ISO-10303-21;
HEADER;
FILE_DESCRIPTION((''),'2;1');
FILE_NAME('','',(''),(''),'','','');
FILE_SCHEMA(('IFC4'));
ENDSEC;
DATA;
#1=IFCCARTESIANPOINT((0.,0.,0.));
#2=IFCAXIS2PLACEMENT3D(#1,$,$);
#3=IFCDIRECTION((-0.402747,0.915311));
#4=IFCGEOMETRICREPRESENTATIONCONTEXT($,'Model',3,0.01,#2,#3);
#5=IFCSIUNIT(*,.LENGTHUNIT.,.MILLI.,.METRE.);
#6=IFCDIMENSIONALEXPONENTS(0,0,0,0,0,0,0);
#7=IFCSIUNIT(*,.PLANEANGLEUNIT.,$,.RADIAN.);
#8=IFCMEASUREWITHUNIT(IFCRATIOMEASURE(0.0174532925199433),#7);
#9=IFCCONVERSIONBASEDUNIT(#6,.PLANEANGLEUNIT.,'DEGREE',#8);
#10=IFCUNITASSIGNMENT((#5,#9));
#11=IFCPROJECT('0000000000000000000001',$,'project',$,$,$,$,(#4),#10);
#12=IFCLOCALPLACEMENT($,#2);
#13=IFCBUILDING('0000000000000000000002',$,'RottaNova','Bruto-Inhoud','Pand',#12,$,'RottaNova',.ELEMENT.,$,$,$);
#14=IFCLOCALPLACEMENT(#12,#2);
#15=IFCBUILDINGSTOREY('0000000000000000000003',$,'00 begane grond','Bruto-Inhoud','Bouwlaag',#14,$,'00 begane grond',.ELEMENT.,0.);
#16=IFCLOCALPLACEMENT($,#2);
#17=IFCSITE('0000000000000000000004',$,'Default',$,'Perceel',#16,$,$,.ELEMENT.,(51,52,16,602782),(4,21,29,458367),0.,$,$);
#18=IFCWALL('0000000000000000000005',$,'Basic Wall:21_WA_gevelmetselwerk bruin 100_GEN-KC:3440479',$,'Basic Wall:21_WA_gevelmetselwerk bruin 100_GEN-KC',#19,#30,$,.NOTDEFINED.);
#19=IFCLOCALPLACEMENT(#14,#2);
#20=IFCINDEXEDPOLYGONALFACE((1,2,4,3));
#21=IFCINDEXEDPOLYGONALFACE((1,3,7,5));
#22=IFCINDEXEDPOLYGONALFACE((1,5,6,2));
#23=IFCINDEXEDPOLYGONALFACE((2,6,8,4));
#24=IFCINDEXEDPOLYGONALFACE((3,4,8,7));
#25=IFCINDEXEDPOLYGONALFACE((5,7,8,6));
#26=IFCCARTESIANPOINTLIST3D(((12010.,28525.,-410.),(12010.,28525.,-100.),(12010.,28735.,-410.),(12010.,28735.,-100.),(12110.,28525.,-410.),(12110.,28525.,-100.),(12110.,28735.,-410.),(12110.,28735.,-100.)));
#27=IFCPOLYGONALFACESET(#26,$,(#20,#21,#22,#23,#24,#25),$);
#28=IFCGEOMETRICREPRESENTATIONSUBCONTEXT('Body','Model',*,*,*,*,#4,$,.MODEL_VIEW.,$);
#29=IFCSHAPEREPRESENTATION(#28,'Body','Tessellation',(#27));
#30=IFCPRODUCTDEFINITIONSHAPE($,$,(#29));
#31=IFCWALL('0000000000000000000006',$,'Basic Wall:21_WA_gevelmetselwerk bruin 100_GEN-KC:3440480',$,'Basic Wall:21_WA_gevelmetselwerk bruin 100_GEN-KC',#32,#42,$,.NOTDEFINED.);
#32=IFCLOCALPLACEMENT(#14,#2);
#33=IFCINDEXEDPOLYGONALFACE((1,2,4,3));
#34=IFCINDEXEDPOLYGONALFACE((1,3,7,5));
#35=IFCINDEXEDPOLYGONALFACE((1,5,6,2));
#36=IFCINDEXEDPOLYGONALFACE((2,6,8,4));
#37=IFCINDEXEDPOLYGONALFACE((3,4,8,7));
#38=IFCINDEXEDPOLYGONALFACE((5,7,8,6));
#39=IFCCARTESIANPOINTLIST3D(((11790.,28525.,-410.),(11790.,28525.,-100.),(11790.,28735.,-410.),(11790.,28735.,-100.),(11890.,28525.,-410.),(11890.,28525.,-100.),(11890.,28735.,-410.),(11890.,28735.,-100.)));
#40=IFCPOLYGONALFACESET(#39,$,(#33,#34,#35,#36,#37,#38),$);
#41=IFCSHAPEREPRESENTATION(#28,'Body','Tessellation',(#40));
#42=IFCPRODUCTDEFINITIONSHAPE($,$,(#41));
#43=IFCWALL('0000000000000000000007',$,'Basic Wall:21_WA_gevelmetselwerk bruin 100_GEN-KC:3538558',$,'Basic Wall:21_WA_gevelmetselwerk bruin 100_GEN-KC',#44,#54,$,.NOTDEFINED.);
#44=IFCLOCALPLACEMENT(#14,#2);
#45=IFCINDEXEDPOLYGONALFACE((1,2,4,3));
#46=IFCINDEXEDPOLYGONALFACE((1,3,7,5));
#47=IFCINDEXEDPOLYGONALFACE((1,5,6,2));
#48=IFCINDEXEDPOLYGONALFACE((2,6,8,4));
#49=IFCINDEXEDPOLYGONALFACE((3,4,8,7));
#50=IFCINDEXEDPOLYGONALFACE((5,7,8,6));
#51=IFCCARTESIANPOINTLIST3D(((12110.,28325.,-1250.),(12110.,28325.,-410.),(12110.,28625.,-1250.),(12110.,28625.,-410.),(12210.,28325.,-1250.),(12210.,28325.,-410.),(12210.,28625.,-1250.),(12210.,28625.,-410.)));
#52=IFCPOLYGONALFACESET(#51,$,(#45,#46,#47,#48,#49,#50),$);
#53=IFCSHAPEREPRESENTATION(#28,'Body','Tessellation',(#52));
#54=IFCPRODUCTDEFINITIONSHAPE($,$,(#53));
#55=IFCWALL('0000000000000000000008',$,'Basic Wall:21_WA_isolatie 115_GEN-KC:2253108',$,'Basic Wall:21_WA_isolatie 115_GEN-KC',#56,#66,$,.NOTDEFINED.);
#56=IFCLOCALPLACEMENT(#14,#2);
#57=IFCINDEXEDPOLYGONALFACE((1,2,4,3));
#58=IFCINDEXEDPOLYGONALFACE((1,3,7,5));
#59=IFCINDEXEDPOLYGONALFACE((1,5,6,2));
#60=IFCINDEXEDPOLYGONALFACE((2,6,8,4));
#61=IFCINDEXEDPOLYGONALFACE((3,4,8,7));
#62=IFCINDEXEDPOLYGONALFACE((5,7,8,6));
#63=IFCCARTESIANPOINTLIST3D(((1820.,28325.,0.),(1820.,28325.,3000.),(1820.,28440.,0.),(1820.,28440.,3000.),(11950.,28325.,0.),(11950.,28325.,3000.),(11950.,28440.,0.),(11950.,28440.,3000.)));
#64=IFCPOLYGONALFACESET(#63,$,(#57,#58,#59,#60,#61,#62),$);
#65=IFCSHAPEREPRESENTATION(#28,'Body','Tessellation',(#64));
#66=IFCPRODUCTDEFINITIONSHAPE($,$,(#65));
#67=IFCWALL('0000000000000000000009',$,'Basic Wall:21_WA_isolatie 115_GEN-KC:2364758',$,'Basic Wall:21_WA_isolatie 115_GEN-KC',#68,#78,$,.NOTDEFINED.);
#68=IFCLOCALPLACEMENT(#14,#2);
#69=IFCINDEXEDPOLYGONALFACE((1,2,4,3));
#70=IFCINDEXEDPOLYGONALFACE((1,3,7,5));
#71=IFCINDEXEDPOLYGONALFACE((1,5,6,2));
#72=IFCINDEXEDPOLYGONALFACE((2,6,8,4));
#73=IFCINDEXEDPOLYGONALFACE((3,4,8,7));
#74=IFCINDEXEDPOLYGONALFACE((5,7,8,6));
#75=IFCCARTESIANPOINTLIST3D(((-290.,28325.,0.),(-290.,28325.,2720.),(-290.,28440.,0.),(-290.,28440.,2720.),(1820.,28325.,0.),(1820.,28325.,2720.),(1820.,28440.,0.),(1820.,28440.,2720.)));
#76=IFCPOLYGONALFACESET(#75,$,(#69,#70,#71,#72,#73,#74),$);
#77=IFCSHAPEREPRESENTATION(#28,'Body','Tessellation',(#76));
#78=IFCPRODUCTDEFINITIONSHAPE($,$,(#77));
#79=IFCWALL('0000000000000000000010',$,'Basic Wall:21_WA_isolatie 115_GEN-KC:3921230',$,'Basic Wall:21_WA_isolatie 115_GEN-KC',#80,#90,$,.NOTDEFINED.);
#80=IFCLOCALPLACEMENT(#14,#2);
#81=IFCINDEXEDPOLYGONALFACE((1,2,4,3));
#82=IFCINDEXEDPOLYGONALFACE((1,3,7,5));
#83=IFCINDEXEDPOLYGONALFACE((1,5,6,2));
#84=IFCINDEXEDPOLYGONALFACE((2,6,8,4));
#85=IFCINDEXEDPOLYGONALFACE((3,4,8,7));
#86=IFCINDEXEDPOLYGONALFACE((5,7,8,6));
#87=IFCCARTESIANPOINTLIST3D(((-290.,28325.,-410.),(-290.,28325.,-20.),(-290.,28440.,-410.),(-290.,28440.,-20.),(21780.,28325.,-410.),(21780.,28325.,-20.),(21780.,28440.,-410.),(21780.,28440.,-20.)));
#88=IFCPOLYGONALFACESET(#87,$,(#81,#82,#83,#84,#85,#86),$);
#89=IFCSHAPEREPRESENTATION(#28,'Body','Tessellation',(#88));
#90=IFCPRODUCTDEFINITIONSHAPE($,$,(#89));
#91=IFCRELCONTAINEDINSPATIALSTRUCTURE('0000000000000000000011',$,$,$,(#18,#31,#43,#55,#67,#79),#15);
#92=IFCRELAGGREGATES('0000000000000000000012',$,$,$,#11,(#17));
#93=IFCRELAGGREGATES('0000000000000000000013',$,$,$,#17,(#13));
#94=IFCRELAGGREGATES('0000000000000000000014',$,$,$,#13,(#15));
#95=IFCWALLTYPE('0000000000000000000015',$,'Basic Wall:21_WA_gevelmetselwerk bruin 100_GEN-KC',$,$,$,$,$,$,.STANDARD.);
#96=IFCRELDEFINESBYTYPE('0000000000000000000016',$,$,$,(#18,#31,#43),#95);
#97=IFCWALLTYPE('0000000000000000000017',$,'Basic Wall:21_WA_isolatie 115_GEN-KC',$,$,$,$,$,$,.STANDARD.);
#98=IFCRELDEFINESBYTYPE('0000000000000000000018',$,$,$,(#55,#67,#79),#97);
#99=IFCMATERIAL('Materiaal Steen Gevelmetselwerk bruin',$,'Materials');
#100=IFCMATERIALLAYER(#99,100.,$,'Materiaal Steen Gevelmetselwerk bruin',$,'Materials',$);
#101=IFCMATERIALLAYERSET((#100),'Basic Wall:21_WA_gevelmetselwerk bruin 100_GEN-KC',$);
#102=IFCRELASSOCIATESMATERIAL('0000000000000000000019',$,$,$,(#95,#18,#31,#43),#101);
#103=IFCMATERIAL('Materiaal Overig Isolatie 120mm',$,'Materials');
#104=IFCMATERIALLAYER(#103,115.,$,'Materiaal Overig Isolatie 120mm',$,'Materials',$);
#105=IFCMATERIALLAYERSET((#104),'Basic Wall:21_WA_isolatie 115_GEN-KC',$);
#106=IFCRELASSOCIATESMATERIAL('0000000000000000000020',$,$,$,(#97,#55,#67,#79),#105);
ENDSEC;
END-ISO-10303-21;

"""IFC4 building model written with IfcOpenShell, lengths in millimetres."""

from ifc_helpers import new_model, entity, si_unit, converted_unit, direction, frame, frame_2d, origin, place, context, subcontext, project, spatial, rectangle, extrude, material, layer, layer_set, type_object, element, save


model = new_model("IFC4")

# Units and contexts
model_context = context("Model", 3, precision=0.01, world=origin(), true_north=direction((-0.402747, 0.915311)))
body_context = subcontext(model_context, "Body", "Model", "MODEL_VIEW")
ifc_project = project(units=[si_unit("LENGTHUNIT", "METRE", prefix="MILLI"), converted_unit("PLANEANGLEUNIT", "DEGREE", entity("IfcRatioMeasure", 0.0174532925199433), si_unit("PLANEANGLEUNIT", "RADIAN"), dimensions=[0, 0, 0, 0, 0, 0, 0])], contexts=[model_context])

# Site, building, storey
site_placement = place(None, origin())
site = spatial("IfcSite", under=ifc_project, at=site_placement, Name="Default", ObjectType="Perceel", CompositionType="ELEMENT", RefLatitude=(51, 52, 16, 602782), RefLongitude=(4, 21, 29, 458367), RefElevation=0.0)
building_placement = place(None, origin())
building = spatial("IfcBuilding", under=site, at=building_placement, Name="RottaNova", Description="Bruto-Inhoud", ObjectType="Pand", LongName="RottaNova", CompositionType="ELEMENT")
storey_placement = place(building_placement, origin())
storey = spatial("IfcBuildingStorey", under=building, at=storey_placement, Name="00 begane grond", Description="Bruto-Inhoud", ObjectType="Bouwlaag", LongName="00 begane grond", CompositionType="ELEMENT", Elevation=0.0)

# Walls
ifc_material_1 = material(Name="Materiaal Steen Gevelmetselwerk bruin", Category="Materials")
ifc_layer_1 = layer(ifc_material_1, 100.0, Name="Materiaal Steen Gevelmetselwerk bruin", Category="Materials")
ifc_layer_set_1 = layer_set([ifc_layer_1], Name="Basic Wall:21_WA_gevelmetselwerk bruin 100_GEN-KC")
wall_type_1 = type_object("IfcWallType", Name="Basic Wall:21_WA_gevelmetselwerk bruin 100_GEN-KC", PredefinedType="STANDARD", material=ifc_layer_set_1)
wall_1_placement = place(storey_placement, frame((12060.0, 28735.0, -410.0), z_axis=(0.0, 0.0, 1.0), x_axis=(0.0, -1.0, 0.0)))
element("IfcWall", 1, at=wall_1_placement, inside=storey, type_object=wall_type_1, material=ifc_layer_set_1, Name="Basic Wall:21_WA_gevelmetselwerk bruin 100_GEN-KC:3440479", ObjectType="Basic Wall:21_WA_gevelmetselwerk bruin 100_GEN-KC", PredefinedType="NOTDEFINED", context=body_context, shape_type="SweptSolid", body=[
    extrude(rectangle(XDim=210.0, YDim=100.0, at=frame_2d((105.0, 0.0), x_axis=(-1.0, 0.0))), origin(), (0.0, 0.0, 1.0), 310.0),
])
wall_2_placement = place(storey_placement, frame((11840.0, 28735.0, -410.0), z_axis=(0.0, 0.0, 1.0), x_axis=(0.0, -1.0, 0.0)))
element("IfcWall", 2, at=wall_2_placement, inside=storey, type_object=wall_type_1, material=ifc_layer_set_1, Name="Basic Wall:21_WA_gevelmetselwerk bruin 100_GEN-KC:3440480", ObjectType="Basic Wall:21_WA_gevelmetselwerk bruin 100_GEN-KC", PredefinedType="NOTDEFINED", context=body_context, shape_type="SweptSolid", body=[
    extrude(rectangle(XDim=210.0, YDim=100.0, at=frame_2d((105.0, 0.0), x_axis=(-1.0, 0.0))), origin(), (0.0, 0.0, 1.0), 310.0),
])
wall_3_placement = place(storey_placement, frame((12160.0, 28325.0, -1250.0), z_axis=(0.0, 0.0, 1.0), x_axis=(0.0, 1.0, 0.0)))
element("IfcWall", 3, at=wall_3_placement, inside=storey, type_object=wall_type_1, material=ifc_layer_set_1, Name="Basic Wall:21_WA_gevelmetselwerk bruin 100_GEN-KC:3538558", ObjectType="Basic Wall:21_WA_gevelmetselwerk bruin 100_GEN-KC", PredefinedType="NOTDEFINED", context=body_context, shape_type="SweptSolid", body=[
    extrude(rectangle(XDim=300.0, YDim=100.0, at=frame_2d((150.0, 0.0), x_axis=(-1.0, 0.0))), origin(), (0.0, 0.0, 1.0), 840.0),
])
ifc_material_2 = material(Name="Materiaal Overig Isolatie 120mm", Category="Materials")
ifc_layer_2 = layer(ifc_material_2, 115.0, Name="Materiaal Overig Isolatie 120mm", Category="Materials")
ifc_layer_set_2 = layer_set([ifc_layer_2], Name="Basic Wall:21_WA_isolatie 115_GEN-KC")
wall_type_2 = type_object("IfcWallType", Name="Basic Wall:21_WA_isolatie 115_GEN-KC", PredefinedType="STANDARD", material=ifc_layer_set_2)
wall_4_placement = place(storey_placement, frame((11950.0, 28382.5, 0.0), z_axis=(0.0, 0.0, 1.0), x_axis=(-1.0, 0.0, 0.0)))
element("IfcWall", 4, at=wall_4_placement, inside=storey, type_object=wall_type_2, material=ifc_layer_set_2, Name="Basic Wall:21_WA_isolatie 115_GEN-KC:2253108", ObjectType="Basic Wall:21_WA_isolatie 115_GEN-KC", PredefinedType="NOTDEFINED", context=body_context, shape_type="SweptSolid", body=[
    extrude(rectangle(XDim=10130.0, YDim=115.0, at=frame_2d((5065.0, 0.0), x_axis=(-1.0, 0.0))), origin(), (0.0, 0.0, 1.0), 3000.0),
])
wall_5_placement = place(storey_placement, frame((1820.0, 28382.5, 0.0), z_axis=(0.0, 0.0, 1.0), x_axis=(-1.0, 0.0, 0.0)))
element("IfcWall", 5, at=wall_5_placement, inside=storey, type_object=wall_type_2, material=ifc_layer_set_2, Name="Basic Wall:21_WA_isolatie 115_GEN-KC:2364758", ObjectType="Basic Wall:21_WA_isolatie 115_GEN-KC", PredefinedType="NOTDEFINED", context=body_context, shape_type="SweptSolid", body=[
    extrude(rectangle(XDim=2110.0, YDim=115.0, at=frame_2d((1055.0, 0.0), x_axis=(-1.0, 0.0))), origin(), (0.0, 0.0, 1.0), 2720.0),
])
wall_6_placement = place(storey_placement, frame((-290.0, 28382.5, -410.0)))
element("IfcWall", 6, at=wall_6_placement, inside=storey, type_object=wall_type_2, material=ifc_layer_set_2, Name="Basic Wall:21_WA_isolatie 115_GEN-KC:3921230", ObjectType="Basic Wall:21_WA_isolatie 115_GEN-KC", PredefinedType="NOTDEFINED", context=body_context, shape_type="SweptSolid", body=[
    extrude(rectangle(XDim=22070.0, YDim=115.0, at=frame_2d((11035.0, 0.0), x_axis=(-1.0, 0.0))), origin(), (0.0, 0.0, 1.0), 390.0),
])

save(model, "model.ifc")
